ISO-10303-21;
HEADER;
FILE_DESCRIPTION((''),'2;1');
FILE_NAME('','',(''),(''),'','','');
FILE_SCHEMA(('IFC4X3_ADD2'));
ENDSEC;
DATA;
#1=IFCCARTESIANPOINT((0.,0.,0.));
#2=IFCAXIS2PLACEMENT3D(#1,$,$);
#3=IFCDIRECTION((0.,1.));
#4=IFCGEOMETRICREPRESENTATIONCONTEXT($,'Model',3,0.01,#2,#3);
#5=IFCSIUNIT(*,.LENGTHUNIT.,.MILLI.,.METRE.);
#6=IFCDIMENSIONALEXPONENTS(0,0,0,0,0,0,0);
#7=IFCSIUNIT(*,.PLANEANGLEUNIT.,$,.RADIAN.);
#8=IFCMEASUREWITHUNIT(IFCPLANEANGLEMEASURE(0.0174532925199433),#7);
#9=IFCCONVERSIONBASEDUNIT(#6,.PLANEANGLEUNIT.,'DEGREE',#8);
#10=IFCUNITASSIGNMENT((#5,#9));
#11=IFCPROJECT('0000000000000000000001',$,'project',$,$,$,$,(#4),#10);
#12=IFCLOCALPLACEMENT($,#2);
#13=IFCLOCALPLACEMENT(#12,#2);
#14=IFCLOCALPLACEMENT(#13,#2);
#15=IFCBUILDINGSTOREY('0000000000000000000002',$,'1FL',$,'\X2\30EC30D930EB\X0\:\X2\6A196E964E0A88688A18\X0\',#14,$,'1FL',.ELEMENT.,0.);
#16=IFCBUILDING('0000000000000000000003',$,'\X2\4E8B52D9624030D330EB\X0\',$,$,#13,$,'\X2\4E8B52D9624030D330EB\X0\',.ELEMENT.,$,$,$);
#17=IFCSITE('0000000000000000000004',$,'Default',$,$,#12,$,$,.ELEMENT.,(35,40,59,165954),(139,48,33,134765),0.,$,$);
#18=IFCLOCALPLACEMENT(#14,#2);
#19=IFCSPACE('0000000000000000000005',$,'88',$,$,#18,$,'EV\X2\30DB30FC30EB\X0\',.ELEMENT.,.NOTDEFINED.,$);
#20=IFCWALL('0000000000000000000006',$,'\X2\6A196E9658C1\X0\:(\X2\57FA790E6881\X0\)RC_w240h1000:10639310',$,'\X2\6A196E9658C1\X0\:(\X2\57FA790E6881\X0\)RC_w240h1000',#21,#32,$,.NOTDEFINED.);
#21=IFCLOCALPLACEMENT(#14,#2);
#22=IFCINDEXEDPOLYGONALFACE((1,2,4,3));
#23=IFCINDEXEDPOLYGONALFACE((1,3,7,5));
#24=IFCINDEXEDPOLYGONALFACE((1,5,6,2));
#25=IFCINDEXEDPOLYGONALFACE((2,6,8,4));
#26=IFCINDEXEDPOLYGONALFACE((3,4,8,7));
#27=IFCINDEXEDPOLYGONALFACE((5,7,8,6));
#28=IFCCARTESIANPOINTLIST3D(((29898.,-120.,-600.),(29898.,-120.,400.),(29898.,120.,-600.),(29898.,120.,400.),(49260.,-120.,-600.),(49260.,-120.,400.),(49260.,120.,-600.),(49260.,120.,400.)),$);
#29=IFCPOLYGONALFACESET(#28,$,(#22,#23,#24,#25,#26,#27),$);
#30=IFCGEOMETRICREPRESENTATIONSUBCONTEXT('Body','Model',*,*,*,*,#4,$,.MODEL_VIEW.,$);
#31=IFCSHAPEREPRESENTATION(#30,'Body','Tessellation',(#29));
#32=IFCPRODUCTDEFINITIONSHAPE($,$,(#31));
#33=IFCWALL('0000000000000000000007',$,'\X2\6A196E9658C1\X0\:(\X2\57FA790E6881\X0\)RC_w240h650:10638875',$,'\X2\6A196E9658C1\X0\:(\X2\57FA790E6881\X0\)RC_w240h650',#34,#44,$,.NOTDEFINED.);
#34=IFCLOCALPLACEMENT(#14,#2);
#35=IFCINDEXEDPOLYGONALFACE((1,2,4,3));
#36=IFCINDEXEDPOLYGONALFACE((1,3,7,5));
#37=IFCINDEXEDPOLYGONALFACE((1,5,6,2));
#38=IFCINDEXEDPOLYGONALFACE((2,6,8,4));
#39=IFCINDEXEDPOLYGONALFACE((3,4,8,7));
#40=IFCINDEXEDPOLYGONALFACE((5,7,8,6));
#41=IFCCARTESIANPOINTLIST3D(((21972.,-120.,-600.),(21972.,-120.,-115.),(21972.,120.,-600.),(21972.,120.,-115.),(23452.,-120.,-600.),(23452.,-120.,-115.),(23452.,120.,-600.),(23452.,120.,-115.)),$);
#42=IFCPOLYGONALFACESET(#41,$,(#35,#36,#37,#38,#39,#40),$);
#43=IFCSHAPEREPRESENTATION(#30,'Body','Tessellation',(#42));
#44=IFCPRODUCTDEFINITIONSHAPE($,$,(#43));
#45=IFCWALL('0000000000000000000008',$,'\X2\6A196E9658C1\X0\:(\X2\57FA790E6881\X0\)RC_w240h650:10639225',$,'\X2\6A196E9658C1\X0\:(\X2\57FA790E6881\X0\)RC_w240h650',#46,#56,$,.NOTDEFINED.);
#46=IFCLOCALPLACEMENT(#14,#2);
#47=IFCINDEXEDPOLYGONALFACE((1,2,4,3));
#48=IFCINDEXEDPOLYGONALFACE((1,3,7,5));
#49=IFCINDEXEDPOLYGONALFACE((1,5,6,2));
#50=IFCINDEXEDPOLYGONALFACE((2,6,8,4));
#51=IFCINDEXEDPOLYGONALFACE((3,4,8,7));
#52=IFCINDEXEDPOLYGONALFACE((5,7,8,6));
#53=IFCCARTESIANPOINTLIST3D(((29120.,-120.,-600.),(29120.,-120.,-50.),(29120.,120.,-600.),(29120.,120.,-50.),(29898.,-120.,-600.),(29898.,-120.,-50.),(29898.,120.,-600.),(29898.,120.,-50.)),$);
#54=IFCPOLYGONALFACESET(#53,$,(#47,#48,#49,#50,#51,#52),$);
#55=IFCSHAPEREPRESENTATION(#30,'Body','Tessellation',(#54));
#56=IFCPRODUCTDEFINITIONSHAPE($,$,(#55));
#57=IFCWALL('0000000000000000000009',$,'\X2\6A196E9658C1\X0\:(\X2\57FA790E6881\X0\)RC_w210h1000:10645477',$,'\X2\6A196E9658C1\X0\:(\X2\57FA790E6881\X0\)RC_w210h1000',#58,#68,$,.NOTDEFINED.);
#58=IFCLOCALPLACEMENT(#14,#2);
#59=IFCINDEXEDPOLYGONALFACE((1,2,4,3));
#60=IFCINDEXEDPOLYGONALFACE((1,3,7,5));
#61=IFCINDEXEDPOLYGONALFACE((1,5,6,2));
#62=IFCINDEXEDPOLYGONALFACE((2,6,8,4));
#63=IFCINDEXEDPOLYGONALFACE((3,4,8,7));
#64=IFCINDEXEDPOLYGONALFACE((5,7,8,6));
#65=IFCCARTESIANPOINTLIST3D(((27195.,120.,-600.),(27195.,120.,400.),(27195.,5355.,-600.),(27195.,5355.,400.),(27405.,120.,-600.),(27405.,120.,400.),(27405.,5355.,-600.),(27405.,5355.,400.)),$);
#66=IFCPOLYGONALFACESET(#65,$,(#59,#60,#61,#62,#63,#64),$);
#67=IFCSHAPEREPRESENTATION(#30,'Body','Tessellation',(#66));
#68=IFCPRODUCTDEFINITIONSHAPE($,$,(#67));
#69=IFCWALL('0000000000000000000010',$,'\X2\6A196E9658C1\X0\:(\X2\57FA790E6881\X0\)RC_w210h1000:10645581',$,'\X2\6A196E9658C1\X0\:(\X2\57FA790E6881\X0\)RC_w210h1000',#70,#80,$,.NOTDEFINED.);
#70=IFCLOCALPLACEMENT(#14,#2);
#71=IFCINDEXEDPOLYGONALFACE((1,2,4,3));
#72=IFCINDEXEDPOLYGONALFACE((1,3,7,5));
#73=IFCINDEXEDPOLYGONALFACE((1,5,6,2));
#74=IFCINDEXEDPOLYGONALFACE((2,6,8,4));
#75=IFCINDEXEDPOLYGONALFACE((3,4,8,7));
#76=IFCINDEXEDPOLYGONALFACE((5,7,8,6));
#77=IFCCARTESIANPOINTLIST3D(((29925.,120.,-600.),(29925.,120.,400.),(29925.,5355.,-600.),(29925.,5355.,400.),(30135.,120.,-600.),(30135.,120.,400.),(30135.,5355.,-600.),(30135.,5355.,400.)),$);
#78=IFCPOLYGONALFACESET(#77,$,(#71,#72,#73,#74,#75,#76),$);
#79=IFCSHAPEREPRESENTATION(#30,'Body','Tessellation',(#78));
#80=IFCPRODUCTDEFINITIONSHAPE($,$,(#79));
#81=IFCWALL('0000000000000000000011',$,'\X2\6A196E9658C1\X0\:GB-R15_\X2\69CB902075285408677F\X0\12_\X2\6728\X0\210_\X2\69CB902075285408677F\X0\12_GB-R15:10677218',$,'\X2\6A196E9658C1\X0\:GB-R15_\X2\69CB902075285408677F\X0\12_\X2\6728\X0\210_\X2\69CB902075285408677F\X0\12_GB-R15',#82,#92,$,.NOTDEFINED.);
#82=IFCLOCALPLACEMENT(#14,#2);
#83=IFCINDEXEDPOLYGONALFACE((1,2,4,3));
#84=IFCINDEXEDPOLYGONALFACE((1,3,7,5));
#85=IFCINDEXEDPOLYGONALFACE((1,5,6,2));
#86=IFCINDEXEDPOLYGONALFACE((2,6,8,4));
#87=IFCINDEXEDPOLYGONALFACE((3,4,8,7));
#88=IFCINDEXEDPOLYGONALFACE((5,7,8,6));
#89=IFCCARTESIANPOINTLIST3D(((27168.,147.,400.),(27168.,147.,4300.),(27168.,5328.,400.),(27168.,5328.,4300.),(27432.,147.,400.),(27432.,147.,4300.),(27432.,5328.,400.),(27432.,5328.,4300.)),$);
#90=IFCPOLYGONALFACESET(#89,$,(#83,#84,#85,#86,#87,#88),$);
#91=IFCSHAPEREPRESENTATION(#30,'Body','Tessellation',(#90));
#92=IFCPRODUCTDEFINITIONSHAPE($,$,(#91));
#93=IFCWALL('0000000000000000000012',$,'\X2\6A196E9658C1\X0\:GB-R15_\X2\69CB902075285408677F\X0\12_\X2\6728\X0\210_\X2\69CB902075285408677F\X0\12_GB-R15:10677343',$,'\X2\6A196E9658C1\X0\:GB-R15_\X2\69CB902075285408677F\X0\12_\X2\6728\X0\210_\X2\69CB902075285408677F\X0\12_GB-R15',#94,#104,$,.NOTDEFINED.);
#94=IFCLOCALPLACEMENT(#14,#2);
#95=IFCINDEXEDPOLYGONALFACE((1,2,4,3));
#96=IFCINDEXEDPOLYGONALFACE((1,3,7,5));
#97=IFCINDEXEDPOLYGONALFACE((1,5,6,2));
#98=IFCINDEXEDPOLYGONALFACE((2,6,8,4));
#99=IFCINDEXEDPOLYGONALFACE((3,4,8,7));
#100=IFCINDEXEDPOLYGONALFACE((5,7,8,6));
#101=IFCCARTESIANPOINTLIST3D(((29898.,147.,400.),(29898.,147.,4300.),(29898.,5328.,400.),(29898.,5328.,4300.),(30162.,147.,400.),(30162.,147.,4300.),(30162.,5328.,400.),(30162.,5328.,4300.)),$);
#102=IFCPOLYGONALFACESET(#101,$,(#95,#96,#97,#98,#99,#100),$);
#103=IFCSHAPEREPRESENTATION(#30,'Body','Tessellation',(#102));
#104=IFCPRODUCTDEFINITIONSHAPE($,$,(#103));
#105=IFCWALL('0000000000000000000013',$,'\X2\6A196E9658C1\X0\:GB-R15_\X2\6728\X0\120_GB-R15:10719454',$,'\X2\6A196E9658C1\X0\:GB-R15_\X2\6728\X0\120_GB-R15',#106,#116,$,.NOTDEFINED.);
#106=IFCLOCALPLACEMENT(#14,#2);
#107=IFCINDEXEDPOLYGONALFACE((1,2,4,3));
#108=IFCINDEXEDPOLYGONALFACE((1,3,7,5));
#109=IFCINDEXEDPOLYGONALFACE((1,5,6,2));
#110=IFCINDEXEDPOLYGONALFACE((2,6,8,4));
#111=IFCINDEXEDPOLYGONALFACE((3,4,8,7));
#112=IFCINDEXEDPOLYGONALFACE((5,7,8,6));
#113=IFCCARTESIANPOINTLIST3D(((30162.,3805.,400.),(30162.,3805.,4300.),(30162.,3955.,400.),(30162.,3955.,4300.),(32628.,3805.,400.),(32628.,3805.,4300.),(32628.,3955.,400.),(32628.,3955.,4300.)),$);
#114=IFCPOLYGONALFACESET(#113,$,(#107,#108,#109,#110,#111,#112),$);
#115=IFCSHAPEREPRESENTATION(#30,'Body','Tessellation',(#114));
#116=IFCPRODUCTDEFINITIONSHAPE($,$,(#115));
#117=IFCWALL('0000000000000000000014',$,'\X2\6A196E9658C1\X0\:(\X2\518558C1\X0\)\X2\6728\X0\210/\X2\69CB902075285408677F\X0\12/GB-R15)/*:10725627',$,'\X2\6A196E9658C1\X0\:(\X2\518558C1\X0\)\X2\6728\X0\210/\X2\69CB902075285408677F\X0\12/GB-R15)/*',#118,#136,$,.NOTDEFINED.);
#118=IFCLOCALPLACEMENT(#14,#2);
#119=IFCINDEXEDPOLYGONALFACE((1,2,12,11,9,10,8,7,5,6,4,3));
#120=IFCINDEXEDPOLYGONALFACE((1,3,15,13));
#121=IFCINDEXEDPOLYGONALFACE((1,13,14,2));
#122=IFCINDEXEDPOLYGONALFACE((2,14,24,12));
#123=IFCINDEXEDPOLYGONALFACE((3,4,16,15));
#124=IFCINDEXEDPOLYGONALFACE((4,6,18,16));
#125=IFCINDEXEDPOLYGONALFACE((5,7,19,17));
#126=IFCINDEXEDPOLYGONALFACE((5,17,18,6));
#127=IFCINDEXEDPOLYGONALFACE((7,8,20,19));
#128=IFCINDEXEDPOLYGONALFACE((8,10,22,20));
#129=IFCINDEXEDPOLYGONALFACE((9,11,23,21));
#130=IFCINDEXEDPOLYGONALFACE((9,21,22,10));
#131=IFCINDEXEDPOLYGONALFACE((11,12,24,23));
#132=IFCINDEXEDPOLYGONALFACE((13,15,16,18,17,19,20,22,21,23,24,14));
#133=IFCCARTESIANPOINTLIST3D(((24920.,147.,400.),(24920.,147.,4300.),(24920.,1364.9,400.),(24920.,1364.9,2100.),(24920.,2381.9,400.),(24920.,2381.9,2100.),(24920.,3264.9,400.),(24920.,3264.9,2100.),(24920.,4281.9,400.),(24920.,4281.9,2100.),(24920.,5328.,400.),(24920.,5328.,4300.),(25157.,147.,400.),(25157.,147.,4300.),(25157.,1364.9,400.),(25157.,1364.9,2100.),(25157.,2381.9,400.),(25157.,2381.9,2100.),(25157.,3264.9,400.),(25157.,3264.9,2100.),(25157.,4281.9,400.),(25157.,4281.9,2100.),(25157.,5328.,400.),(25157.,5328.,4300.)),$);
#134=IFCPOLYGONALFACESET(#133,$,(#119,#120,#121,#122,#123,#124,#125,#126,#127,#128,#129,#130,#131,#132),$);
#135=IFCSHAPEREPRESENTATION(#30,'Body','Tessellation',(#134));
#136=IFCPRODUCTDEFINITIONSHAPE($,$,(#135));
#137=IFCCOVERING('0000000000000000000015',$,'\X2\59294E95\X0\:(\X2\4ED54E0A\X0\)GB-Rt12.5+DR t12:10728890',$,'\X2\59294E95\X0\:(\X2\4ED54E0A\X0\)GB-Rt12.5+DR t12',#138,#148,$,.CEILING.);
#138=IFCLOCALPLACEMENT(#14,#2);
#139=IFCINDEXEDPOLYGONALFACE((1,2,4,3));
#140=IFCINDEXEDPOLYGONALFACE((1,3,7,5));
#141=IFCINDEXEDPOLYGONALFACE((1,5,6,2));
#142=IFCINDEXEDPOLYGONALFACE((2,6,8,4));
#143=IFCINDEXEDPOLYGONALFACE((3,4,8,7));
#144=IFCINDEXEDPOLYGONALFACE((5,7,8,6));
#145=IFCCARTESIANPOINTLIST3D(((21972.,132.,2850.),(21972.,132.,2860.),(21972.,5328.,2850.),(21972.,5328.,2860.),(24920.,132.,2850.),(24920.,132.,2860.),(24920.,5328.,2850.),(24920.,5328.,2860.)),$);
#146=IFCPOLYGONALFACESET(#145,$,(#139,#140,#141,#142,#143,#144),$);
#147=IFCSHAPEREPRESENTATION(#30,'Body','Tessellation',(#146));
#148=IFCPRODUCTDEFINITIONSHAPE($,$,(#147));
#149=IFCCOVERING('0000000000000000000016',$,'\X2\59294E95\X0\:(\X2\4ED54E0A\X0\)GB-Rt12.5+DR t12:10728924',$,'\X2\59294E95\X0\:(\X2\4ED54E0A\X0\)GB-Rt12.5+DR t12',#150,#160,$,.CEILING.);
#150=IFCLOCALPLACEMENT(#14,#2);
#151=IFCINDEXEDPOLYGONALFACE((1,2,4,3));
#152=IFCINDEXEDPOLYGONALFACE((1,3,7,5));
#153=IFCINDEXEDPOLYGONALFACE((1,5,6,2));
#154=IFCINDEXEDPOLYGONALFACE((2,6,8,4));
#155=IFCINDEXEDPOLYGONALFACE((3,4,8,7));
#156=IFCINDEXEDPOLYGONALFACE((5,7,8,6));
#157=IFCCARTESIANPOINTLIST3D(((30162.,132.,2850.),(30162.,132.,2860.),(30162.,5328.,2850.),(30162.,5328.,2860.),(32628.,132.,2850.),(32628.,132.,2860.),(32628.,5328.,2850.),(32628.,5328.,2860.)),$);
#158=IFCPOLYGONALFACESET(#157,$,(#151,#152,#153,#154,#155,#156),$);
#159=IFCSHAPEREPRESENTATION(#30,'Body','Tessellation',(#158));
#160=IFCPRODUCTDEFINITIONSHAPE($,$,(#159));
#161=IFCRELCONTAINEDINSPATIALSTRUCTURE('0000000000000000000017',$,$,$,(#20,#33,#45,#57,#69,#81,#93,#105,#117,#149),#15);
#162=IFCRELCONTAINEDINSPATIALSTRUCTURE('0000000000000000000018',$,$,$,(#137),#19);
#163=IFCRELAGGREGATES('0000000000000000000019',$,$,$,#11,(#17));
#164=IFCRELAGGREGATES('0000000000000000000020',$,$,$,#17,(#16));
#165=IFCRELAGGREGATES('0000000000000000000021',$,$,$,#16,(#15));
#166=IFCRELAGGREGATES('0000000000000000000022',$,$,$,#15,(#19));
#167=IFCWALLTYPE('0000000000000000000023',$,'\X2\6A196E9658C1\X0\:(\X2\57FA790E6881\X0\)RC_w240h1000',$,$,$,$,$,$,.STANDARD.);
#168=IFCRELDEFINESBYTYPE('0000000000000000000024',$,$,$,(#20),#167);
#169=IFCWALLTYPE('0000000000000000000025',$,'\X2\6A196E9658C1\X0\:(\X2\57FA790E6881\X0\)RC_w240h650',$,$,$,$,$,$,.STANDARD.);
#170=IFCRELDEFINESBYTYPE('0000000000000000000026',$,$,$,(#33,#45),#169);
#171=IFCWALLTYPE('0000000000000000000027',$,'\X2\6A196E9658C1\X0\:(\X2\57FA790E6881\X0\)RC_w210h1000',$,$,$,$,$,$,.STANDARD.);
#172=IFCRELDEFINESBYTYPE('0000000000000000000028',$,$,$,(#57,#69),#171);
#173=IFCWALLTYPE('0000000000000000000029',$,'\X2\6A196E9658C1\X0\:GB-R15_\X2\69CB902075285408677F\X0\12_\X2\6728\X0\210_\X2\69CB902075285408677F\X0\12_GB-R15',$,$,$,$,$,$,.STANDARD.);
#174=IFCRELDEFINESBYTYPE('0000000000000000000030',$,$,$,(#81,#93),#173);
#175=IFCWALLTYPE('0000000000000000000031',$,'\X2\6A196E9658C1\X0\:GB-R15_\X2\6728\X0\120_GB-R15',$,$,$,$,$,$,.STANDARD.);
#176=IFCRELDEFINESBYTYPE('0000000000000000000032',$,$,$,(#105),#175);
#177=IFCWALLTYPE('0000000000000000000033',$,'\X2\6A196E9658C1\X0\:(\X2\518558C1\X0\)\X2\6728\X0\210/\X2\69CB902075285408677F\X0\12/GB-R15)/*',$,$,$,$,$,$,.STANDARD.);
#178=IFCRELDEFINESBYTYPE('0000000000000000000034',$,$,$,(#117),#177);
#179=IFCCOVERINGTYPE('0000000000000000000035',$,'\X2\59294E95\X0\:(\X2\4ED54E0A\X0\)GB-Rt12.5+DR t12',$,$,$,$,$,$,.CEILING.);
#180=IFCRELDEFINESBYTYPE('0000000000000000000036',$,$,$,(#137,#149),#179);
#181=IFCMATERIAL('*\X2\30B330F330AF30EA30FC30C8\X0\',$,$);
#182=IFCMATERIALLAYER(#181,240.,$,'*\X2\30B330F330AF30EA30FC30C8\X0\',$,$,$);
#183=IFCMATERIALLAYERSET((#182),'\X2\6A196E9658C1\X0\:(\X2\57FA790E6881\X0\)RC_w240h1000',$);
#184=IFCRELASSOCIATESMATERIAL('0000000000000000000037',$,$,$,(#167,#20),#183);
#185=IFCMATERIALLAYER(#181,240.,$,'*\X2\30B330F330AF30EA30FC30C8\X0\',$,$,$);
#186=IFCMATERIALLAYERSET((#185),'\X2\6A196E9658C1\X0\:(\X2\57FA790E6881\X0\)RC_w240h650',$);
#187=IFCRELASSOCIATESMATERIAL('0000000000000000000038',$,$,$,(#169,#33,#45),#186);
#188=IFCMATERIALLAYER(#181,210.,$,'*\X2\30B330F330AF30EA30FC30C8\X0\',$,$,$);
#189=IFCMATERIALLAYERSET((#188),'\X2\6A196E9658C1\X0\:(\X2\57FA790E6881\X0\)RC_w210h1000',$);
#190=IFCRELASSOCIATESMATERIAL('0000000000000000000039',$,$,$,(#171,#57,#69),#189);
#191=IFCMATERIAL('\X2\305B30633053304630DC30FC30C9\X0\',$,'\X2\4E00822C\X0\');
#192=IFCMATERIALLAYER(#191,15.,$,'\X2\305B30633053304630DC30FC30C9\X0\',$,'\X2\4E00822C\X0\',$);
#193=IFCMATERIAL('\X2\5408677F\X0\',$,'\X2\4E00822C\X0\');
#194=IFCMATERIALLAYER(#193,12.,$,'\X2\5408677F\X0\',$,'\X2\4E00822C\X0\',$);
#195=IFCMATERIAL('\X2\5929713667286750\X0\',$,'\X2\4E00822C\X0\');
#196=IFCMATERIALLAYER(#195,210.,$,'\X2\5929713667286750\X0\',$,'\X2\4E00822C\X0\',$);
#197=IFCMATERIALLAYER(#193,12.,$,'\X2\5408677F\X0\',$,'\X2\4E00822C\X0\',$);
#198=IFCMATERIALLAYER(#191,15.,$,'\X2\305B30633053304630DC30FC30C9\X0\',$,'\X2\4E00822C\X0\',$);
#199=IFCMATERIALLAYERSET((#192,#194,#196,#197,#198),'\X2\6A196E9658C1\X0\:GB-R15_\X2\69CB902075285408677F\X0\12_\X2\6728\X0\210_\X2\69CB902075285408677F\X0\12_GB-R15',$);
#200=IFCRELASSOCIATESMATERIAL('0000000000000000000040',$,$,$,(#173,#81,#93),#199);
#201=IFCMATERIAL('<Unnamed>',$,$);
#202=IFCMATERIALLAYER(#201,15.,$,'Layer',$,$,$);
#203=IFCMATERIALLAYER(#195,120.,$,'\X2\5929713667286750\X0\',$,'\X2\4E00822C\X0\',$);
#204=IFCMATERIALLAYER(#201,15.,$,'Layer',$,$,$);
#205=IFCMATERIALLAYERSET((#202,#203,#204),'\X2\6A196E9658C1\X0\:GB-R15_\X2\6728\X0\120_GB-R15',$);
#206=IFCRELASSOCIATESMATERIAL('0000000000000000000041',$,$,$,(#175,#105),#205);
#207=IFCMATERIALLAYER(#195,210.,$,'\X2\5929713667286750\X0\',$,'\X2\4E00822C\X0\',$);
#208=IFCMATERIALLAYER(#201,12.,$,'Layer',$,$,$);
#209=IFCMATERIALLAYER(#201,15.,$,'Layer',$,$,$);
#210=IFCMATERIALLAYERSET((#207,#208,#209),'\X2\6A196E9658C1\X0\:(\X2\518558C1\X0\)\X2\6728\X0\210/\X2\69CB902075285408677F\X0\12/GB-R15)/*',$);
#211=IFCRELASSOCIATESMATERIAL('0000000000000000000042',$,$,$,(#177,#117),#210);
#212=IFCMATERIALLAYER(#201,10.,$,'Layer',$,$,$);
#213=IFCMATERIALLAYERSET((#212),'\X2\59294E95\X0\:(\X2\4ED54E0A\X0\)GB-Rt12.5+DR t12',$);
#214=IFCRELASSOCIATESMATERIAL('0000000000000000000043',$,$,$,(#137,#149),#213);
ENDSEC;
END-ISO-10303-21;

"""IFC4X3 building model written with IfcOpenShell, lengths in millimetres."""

from ifc_helpers import new_model, entity, si_unit, converted_unit, direction, frame, frame_2d, origin, place, context, subcontext, project, spatial, rectangle, extrude, material, layer, layer_set, layer_usage, type_object, element, save


model = new_model("IFC4X3")

# Units and contexts
model_context = context("Model", 3, precision=0.01, world=origin(), true_north=direction((0.0, 1.0)))
body_context = subcontext(model_context, "Body", "Model", "MODEL_VIEW")
ifc_project = project(units=[si_unit("LENGTHUNIT", "METRE", prefix="MILLI"), converted_unit("PLANEANGLEUNIT", "DEGREE", entity("IfcPlaneAngleMeasure", 0.0174532925199433), si_unit("PLANEANGLEUNIT", "RADIAN"), dimensions=[0, 0, 0, 0, 0, 0, 0])], contexts=[model_context])

# Site, building, storey
site_placement = place(None, origin())
site = spatial("IfcSite", under=ifc_project, at=site_placement, Name="Default", CompositionType="ELEMENT", RefLatitude=(35, 40, 59, 165954), RefLongitude=(139, 48, 33, 134765), RefElevation=0.0)
building_placement = place(site_placement, origin())
building = spatial("IfcBuilding", under=site, at=building_placement, Name="事務所ビル", LongName="事務所ビル", CompositionType="ELEMENT")
storey_placement = place(building_placement, origin())
storey = spatial("IfcBuildingStorey", under=building, at=storey_placement, Name="1FL", ObjectType="レベル:標準上表記", LongName="1FL", CompositionType="ELEMENT", Elevation=0.0)

# Shared definitions
ifc_material_1 = material(Name="*コンクリート")
ifc_layer_1 = layer(ifc_material_1, 240.0, Name="*コンクリート")
ifc_layer_set_1 = layer_set([ifc_layer_1], Name="標準壁:(基礎梁)RC_w240h1000")
wall_type_1 = type_object("IfcWallType", Name="標準壁:(基礎梁)RC_w240h1000", PredefinedType="STANDARD", material=ifc_layer_set_1)

# Wall
wall_1_placement = place(storey_placement, frame((29898.0, 0.0, -600.0)))
element("IfcWall", 1, at=wall_1_placement, inside=storey, type_object=wall_type_1, material=ifc_layer_set_1, Name="標準壁:(基礎梁)RC_w240h1000:10639310", ObjectType="標準壁:(基礎梁)RC_w240h1000", PredefinedType="NOTDEFINED", context=body_context, shape_type="SweptSolid", body=[
    extrude(rectangle(XDim=19362.0, YDim=240.0, at=frame_2d((9681.0, 0.0), x_axis=(-1.0, 0.0))), origin(), (0.0, 0.0, 1.0), 1000.0),
])

# Wall, opening
ifc_layer_2 = layer(ifc_material_1, 240.0, Name="*コンクリート")
ifc_layer_set_2 = layer_set([ifc_layer_2], Name="標準壁:(基礎梁)RC_w240h650")
wall_type_2 = type_object("IfcWallType", Name="標準壁:(基礎梁)RC_w240h650", PredefinedType="STANDARD", material=ifc_layer_set_2)
wall_2_placement = place(storey_placement, frame((21972.0, 0.0, -600.0)))
wall_2 = element("IfcWall", 2, at=wall_2_placement, inside=storey, type_object=wall_type_2, material=ifc_layer_set_2, Name="標準壁:(基礎梁)RC_w240h650:10638875", ObjectType="標準壁:(基礎梁)RC_w240h650", PredefinedType="NOTDEFINED", context=body_context, shape_type="SweptSolid", body=[
    extrude(rectangle(XDim=1480.0, YDim=240.0, at=frame_2d((740.0, 0.0), x_axis=(-1.0, 0.0))), origin(), (0.0, 0.0, 1.0), 485.0),
])
opening_1_placement = place(wall_2_placement, frame((1480.0, 120.0, 485.0)))
element("IfcOpeningElement", 3, at=opening_1_placement, cuts=wall_2, PredefinedType="OPENING", context=body_context, shape_type="SweptSolid", body=[
    extrude(rectangle(XDim=2055.0, YDim=1480.0, at=frame_2d((1027.5, 740.0), x_axis=(-1.0, 0.0))), frame((0.0, 0.0, 0.0), z_axis=(0.0, -1.0, 0.0), x_axis=(0.0, 0.0, 1.0)), (0.0, 0.0, 1.0), 240.0),
])

# Walls
wall_3_placement = place(storey_placement, frame((29120.0, 0.0, -600.0)))
element("IfcWall", 4, at=wall_3_placement, inside=storey, type_object=wall_type_2, material=ifc_layer_set_2, Name="標準壁:(基礎梁)RC_w240h650:10639225", ObjectType="標準壁:(基礎梁)RC_w240h650", PredefinedType="NOTDEFINED", context=body_context, shape_type="SweptSolid", body=[
    extrude(rectangle(XDim=778.0, YDim=240.0, at=frame_2d((389.0, 0.0), x_axis=(-1.0, 0.0))), origin(), (0.0, 0.0, 1.0), 550.0),
])
ifc_layer_3 = layer(ifc_material_1, 210.0, Name="*コンクリート")
ifc_layer_set_3 = layer_set([ifc_layer_3], Name="標準壁:(基礎梁)RC_w210h1000")
wall_type_3 = type_object("IfcWallType", Name="標準壁:(基礎梁)RC_w210h1000", PredefinedType="STANDARD", material=ifc_layer_set_3)
for number, where, z_axis, x_axis, name in (
    (5, (27300.0, 120.0, -600.0), (0.0, 0.0, 1.0), (0.0, 1.0, 0.0), "標準壁:(基礎梁)RC_w210h1000:10645477"),
    (6, (30030.0, 120.0, -600.0), (0.0, 0.0, 1.0), (0.0, 1.0, 0.0), "標準壁:(基礎梁)RC_w210h1000:10645581"),
):
    element("IfcWall", number, at=place(storey_placement, frame(where, z_axis=z_axis, x_axis=x_axis)), inside=storey, type_object=wall_type_3, material=ifc_layer_set_3, Name=name, ObjectType="標準壁:(基礎梁)RC_w210h1000", PredefinedType="NOTDEFINED", context=body_context, shape_type="SweptSolid", body=[
        extrude(rectangle(XDim=5235.0, YDim=210.0, at=frame_2d((2617.5, 0.0), x_axis=(-1.0, 0.0))), origin(), (0.0, 0.0, 1.0), 1000.0),
    ])
ifc_material_2 = material(Name="せっこうボード", Category="一般")
ifc_layer_4 = layer(ifc_material_2, 15.0, Name="せっこうボード", Category="一般")
ifc_material_3 = material(Name="合板", Category="一般")
ifc_layer_5 = layer(ifc_material_3, 12.0, Name="合板", Category="一般")
ifc_material_4 = material(Name="天然木材", Category="一般")
ifc_layer_6 = layer(ifc_material_4, 210.0, Name="天然木材", Category="一般")
ifc_layer_7 = layer(ifc_material_3, 12.0, Name="合板", Category="一般")
ifc_layer_8 = layer(ifc_material_2, 15.0, Name="せっこうボード", Category="一般")
ifc_layer_set_4 = layer_set([ifc_layer_4, ifc_layer_5, ifc_layer_6, ifc_layer_7, ifc_layer_8], Name="標準壁:GB-R15_構造用合板12_木210_構造用合板12_GB-R15")
wall_type_4 = type_object("IfcWallType", Name="標準壁:GB-R15_構造用合板12_木210_構造用合板12_GB-R15", PredefinedType="STANDARD", material=ifc_layer_set_4)
wall_4_placement = place(storey_placement, frame((27300.0, 147.0, 400.0), z_axis=(0.0, 0.0, 1.0), x_axis=(0.0, 1.0, 0.0)))
element("IfcWall", 7, at=wall_4_placement, inside=storey, type_object=wall_type_4, material=ifc_layer_set_4, Name="標準壁:GB-R15_構造用合板12_木210_構造用合板12_GB-R15:10677218", ObjectType="標準壁:GB-R15_構造用合板12_木210_構造用合板12_GB-R15", PredefinedType="NOTDEFINED", context=body_context, shape_type="SweptSolid", body=[
    extrude(rectangle(XDim=5181.0, YDim=264.0, at=frame_2d((2590.5, 0.0), x_axis=(-1.0, 0.0))), origin(), (0.0, 0.0, 1.0), 3900.0),
])
wall_5_placement = place(storey_placement, frame((30030.0, 147.0, 400.0), z_axis=(0.0, 0.0, 1.0), x_axis=(0.0, 1.0, 0.0)))
element("IfcWall", 8, at=wall_5_placement, inside=storey, type_object=wall_type_4, material=ifc_layer_set_4, Name="標準壁:GB-R15_構造用合板12_木210_構造用合板12_GB-R15:10677343", ObjectType="標準壁:GB-R15_構造用合板12_木210_構造用合板12_GB-R15", PredefinedType="NOTDEFINED", context=body_context, shape_type="SweptSolid", body=[
    extrude(rectangle(XDim=5181.0, YDim=264.0, at=frame_2d((2590.5, 0.0), x_axis=(-1.0, 0.0))), origin(), (0.0, 0.0, 1.0), 3900.0),
])
ifc_material_5 = material(Name="<Unnamed>")
ifc_layer_9 = layer(ifc_material_5, 15.0, Name="Layer")
ifc_layer_10 = layer(ifc_material_4, 120.0, Name="天然木材", Category="一般")
ifc_layer_11 = layer(ifc_material_5, 15.0, Name="Layer")
ifc_layer_set_5 = layer_set([ifc_layer_9, ifc_layer_10, ifc_layer_11], Name="標準壁:GB-R15_木120_GB-R15")
wall_type_5 = type_object("IfcWallType", Name="標準壁:GB-R15_木120_GB-R15", PredefinedType="STANDARD", material=ifc_layer_set_5)
wall_6_placement = place(storey_placement, frame((32628.0, 3880.0, 400.0), z_axis=(0.0, 0.0, 1.0), x_axis=(-1.0, 0.0, 0.0)))
element("IfcWall", 9, at=wall_6_placement, inside=storey, type_object=wall_type_5, material=ifc_layer_set_5, Name="標準壁:GB-R15_木120_GB-R15:10719454", ObjectType="標準壁:GB-R15_木120_GB-R15", PredefinedType="NOTDEFINED", context=body_context, shape_type="SweptSolid", body=[
    extrude(rectangle(XDim=2466.0, YDim=150.0, at=frame_2d((1233.0, 0.0), x_axis=(-1.0, 0.0))), origin(), (0.0, 0.0, 1.0), 3900.0),
])

# Wall, openings
ifc_layer_12 = layer(ifc_material_4, 210.0, Name="天然木材", Category="一般")
ifc_layer_13 = layer(ifc_material_5, 12.0, Name="Layer")
ifc_layer_14 = layer(ifc_material_5, 15.0, Name="Layer")
ifc_layer_set_6 = layer_set([ifc_layer_12, ifc_layer_13, ifc_layer_14], Name="標準壁:(内壁)木210/構造用合板12/GB-R15)/*")
wall_type_6 = type_object("IfcWallType", Name="標準壁:(内壁)木210/構造用合板12/GB-R15)/*", PredefinedType="STANDARD", material=ifc_layer_set_6)
wall_7_placement = place(storey_placement, frame((25038.5, 147.0, 400.0), z_axis=(0.0, 0.0, 1.0), x_axis=(0.0, 1.0, 0.0)))
wall_7 = element("IfcWall", 10, at=wall_7_placement, inside=storey, type_object=wall_type_6, material=ifc_layer_set_6, Name="標準壁:(内壁)木210/構造用合板12/GB-R15)/*:10725627", ObjectType="標準壁:(内壁)木210/構造用合板12/GB-R15)/*", PredefinedType="NOTDEFINED", context=body_context, shape_type="SweptSolid", body=[
    extrude(rectangle(XDim=5181.0, YDim=237.0, at=frame_2d((2590.5, 0.0), x_axis=(-1.0, 0.0))), origin(), (0.0, 0.0, 1.0), 3900.0),
])
opening_2_placement = place(wall_7_placement, frame((-147.0, 25038.5, -400.0)))
element("IfcOpeningElement", 11, at=opening_2_placement, cuts=wall_7, PredefinedType="OPENING", context=body_context, shape_type="SweptSolid", body=[
    extrude(rectangle(XDim=2100.0, YDim=1017.0, at=frame_2d((0.0, 0.0), x_axis=(1.0, 0.0))), frame((3773.4, -26444.0, 1050.0), z_axis=(0.0, 1.0, 0.0), x_axis=(0.0, 0.0, -1.0)), (0.0, 0.0, 1.0), 3048.0),
])
opening_3_placement = place(wall_7_placement, frame((-147.0, 25038.5, -400.0)))
element("IfcOpeningElement", 12, at=opening_3_placement, cuts=wall_7, PredefinedType="OPENING", context=body_context, shape_type="SweptSolid", body=[
    extrude(rectangle(XDim=2100.0, YDim=1017.0, at=frame_2d((0.0, 0.0), x_axis=(0.0, 1.0))), frame((1873.4, -26444.0, 1050.0), z_axis=(0.0, 1.0, 0.0), x_axis=(1.0, 0.0, 0.0)), (0.0, 0.0, 1.0), 3048.0),
])

# Shared definitions
space_placement = place(storey_placement, origin())
space = spatial("IfcSpace", under=storey, at=space_placement, Name="88", LongName="EVホール", CompositionType="ELEMENT", PredefinedType="NOTDEFINED")

# Coverings
ifc_layer_15 = layer(ifc_material_5, 10.0, Name="Layer")
ifc_layer_set_7 = layer_set([ifc_layer_15], Name="天井:(仕上)GB-Rt12.5+DR t12")
ifc_layer_usage_1 = layer_usage(ifc_layer_set_7, "AXIS3", "NEGATIVE", 0.0)
covering_type = type_object("IfcCoveringType", Name="天井:(仕上)GB-Rt12.5+DR t12", PredefinedType="CEILING")
covering_1_placement = place(space_placement, frame((21972.0, 132.0, 2850.0)))
element("IfcCovering", 13, at=covering_1_placement, inside=space, type_object=covering_type, material=ifc_layer_usage_1, Name="天井:(仕上)GB-Rt12.5+DR t12:10728890", ObjectType="天井:(仕上)GB-Rt12.5+DR t12", PredefinedType="CEILING", context=body_context, shape_type="SweptSolid", body=[
    extrude(rectangle(XDim=2948.0, YDim=5196.0, at=frame_2d((0.0, 0.0), x_axis=(1.0, 0.0))), frame((1474.0, 2598.0, 0.0), z_axis=(0.0, 0.0, 1.0), x_axis=(-1.0, 0.0, 0.0)), (0.0, 0.0, 1.0), 10.0),
])
ifc_layer_usage_2 = layer_usage(ifc_layer_set_7, "AXIS3", "NEGATIVE", 0.0)
covering_2_placement = place(storey_placement, frame((30162.0, 132.0, 2850.0)))
element("IfcCovering", 14, at=covering_2_placement, inside=storey, type_object=covering_type, material=ifc_layer_usage_2, Name="天井:(仕上)GB-Rt12.5+DR t12:10728924", ObjectType="天井:(仕上)GB-Rt12.5+DR t12", PredefinedType="CEILING", context=body_context, shape_type="SweptSolid", body=[
    extrude(rectangle(XDim=2466.0, YDim=5196.0, at=frame_2d((0.0, 0.0), x_axis=(1.0, 0.0))), frame((1233.0, 2598.0, 0.0), z_axis=(0.0, 0.0, 1.0), x_axis=(-1.0, 0.0, 0.0)), (0.0, 0.0, 1.0), 10.0),
])

save(model, "model.ifc")
